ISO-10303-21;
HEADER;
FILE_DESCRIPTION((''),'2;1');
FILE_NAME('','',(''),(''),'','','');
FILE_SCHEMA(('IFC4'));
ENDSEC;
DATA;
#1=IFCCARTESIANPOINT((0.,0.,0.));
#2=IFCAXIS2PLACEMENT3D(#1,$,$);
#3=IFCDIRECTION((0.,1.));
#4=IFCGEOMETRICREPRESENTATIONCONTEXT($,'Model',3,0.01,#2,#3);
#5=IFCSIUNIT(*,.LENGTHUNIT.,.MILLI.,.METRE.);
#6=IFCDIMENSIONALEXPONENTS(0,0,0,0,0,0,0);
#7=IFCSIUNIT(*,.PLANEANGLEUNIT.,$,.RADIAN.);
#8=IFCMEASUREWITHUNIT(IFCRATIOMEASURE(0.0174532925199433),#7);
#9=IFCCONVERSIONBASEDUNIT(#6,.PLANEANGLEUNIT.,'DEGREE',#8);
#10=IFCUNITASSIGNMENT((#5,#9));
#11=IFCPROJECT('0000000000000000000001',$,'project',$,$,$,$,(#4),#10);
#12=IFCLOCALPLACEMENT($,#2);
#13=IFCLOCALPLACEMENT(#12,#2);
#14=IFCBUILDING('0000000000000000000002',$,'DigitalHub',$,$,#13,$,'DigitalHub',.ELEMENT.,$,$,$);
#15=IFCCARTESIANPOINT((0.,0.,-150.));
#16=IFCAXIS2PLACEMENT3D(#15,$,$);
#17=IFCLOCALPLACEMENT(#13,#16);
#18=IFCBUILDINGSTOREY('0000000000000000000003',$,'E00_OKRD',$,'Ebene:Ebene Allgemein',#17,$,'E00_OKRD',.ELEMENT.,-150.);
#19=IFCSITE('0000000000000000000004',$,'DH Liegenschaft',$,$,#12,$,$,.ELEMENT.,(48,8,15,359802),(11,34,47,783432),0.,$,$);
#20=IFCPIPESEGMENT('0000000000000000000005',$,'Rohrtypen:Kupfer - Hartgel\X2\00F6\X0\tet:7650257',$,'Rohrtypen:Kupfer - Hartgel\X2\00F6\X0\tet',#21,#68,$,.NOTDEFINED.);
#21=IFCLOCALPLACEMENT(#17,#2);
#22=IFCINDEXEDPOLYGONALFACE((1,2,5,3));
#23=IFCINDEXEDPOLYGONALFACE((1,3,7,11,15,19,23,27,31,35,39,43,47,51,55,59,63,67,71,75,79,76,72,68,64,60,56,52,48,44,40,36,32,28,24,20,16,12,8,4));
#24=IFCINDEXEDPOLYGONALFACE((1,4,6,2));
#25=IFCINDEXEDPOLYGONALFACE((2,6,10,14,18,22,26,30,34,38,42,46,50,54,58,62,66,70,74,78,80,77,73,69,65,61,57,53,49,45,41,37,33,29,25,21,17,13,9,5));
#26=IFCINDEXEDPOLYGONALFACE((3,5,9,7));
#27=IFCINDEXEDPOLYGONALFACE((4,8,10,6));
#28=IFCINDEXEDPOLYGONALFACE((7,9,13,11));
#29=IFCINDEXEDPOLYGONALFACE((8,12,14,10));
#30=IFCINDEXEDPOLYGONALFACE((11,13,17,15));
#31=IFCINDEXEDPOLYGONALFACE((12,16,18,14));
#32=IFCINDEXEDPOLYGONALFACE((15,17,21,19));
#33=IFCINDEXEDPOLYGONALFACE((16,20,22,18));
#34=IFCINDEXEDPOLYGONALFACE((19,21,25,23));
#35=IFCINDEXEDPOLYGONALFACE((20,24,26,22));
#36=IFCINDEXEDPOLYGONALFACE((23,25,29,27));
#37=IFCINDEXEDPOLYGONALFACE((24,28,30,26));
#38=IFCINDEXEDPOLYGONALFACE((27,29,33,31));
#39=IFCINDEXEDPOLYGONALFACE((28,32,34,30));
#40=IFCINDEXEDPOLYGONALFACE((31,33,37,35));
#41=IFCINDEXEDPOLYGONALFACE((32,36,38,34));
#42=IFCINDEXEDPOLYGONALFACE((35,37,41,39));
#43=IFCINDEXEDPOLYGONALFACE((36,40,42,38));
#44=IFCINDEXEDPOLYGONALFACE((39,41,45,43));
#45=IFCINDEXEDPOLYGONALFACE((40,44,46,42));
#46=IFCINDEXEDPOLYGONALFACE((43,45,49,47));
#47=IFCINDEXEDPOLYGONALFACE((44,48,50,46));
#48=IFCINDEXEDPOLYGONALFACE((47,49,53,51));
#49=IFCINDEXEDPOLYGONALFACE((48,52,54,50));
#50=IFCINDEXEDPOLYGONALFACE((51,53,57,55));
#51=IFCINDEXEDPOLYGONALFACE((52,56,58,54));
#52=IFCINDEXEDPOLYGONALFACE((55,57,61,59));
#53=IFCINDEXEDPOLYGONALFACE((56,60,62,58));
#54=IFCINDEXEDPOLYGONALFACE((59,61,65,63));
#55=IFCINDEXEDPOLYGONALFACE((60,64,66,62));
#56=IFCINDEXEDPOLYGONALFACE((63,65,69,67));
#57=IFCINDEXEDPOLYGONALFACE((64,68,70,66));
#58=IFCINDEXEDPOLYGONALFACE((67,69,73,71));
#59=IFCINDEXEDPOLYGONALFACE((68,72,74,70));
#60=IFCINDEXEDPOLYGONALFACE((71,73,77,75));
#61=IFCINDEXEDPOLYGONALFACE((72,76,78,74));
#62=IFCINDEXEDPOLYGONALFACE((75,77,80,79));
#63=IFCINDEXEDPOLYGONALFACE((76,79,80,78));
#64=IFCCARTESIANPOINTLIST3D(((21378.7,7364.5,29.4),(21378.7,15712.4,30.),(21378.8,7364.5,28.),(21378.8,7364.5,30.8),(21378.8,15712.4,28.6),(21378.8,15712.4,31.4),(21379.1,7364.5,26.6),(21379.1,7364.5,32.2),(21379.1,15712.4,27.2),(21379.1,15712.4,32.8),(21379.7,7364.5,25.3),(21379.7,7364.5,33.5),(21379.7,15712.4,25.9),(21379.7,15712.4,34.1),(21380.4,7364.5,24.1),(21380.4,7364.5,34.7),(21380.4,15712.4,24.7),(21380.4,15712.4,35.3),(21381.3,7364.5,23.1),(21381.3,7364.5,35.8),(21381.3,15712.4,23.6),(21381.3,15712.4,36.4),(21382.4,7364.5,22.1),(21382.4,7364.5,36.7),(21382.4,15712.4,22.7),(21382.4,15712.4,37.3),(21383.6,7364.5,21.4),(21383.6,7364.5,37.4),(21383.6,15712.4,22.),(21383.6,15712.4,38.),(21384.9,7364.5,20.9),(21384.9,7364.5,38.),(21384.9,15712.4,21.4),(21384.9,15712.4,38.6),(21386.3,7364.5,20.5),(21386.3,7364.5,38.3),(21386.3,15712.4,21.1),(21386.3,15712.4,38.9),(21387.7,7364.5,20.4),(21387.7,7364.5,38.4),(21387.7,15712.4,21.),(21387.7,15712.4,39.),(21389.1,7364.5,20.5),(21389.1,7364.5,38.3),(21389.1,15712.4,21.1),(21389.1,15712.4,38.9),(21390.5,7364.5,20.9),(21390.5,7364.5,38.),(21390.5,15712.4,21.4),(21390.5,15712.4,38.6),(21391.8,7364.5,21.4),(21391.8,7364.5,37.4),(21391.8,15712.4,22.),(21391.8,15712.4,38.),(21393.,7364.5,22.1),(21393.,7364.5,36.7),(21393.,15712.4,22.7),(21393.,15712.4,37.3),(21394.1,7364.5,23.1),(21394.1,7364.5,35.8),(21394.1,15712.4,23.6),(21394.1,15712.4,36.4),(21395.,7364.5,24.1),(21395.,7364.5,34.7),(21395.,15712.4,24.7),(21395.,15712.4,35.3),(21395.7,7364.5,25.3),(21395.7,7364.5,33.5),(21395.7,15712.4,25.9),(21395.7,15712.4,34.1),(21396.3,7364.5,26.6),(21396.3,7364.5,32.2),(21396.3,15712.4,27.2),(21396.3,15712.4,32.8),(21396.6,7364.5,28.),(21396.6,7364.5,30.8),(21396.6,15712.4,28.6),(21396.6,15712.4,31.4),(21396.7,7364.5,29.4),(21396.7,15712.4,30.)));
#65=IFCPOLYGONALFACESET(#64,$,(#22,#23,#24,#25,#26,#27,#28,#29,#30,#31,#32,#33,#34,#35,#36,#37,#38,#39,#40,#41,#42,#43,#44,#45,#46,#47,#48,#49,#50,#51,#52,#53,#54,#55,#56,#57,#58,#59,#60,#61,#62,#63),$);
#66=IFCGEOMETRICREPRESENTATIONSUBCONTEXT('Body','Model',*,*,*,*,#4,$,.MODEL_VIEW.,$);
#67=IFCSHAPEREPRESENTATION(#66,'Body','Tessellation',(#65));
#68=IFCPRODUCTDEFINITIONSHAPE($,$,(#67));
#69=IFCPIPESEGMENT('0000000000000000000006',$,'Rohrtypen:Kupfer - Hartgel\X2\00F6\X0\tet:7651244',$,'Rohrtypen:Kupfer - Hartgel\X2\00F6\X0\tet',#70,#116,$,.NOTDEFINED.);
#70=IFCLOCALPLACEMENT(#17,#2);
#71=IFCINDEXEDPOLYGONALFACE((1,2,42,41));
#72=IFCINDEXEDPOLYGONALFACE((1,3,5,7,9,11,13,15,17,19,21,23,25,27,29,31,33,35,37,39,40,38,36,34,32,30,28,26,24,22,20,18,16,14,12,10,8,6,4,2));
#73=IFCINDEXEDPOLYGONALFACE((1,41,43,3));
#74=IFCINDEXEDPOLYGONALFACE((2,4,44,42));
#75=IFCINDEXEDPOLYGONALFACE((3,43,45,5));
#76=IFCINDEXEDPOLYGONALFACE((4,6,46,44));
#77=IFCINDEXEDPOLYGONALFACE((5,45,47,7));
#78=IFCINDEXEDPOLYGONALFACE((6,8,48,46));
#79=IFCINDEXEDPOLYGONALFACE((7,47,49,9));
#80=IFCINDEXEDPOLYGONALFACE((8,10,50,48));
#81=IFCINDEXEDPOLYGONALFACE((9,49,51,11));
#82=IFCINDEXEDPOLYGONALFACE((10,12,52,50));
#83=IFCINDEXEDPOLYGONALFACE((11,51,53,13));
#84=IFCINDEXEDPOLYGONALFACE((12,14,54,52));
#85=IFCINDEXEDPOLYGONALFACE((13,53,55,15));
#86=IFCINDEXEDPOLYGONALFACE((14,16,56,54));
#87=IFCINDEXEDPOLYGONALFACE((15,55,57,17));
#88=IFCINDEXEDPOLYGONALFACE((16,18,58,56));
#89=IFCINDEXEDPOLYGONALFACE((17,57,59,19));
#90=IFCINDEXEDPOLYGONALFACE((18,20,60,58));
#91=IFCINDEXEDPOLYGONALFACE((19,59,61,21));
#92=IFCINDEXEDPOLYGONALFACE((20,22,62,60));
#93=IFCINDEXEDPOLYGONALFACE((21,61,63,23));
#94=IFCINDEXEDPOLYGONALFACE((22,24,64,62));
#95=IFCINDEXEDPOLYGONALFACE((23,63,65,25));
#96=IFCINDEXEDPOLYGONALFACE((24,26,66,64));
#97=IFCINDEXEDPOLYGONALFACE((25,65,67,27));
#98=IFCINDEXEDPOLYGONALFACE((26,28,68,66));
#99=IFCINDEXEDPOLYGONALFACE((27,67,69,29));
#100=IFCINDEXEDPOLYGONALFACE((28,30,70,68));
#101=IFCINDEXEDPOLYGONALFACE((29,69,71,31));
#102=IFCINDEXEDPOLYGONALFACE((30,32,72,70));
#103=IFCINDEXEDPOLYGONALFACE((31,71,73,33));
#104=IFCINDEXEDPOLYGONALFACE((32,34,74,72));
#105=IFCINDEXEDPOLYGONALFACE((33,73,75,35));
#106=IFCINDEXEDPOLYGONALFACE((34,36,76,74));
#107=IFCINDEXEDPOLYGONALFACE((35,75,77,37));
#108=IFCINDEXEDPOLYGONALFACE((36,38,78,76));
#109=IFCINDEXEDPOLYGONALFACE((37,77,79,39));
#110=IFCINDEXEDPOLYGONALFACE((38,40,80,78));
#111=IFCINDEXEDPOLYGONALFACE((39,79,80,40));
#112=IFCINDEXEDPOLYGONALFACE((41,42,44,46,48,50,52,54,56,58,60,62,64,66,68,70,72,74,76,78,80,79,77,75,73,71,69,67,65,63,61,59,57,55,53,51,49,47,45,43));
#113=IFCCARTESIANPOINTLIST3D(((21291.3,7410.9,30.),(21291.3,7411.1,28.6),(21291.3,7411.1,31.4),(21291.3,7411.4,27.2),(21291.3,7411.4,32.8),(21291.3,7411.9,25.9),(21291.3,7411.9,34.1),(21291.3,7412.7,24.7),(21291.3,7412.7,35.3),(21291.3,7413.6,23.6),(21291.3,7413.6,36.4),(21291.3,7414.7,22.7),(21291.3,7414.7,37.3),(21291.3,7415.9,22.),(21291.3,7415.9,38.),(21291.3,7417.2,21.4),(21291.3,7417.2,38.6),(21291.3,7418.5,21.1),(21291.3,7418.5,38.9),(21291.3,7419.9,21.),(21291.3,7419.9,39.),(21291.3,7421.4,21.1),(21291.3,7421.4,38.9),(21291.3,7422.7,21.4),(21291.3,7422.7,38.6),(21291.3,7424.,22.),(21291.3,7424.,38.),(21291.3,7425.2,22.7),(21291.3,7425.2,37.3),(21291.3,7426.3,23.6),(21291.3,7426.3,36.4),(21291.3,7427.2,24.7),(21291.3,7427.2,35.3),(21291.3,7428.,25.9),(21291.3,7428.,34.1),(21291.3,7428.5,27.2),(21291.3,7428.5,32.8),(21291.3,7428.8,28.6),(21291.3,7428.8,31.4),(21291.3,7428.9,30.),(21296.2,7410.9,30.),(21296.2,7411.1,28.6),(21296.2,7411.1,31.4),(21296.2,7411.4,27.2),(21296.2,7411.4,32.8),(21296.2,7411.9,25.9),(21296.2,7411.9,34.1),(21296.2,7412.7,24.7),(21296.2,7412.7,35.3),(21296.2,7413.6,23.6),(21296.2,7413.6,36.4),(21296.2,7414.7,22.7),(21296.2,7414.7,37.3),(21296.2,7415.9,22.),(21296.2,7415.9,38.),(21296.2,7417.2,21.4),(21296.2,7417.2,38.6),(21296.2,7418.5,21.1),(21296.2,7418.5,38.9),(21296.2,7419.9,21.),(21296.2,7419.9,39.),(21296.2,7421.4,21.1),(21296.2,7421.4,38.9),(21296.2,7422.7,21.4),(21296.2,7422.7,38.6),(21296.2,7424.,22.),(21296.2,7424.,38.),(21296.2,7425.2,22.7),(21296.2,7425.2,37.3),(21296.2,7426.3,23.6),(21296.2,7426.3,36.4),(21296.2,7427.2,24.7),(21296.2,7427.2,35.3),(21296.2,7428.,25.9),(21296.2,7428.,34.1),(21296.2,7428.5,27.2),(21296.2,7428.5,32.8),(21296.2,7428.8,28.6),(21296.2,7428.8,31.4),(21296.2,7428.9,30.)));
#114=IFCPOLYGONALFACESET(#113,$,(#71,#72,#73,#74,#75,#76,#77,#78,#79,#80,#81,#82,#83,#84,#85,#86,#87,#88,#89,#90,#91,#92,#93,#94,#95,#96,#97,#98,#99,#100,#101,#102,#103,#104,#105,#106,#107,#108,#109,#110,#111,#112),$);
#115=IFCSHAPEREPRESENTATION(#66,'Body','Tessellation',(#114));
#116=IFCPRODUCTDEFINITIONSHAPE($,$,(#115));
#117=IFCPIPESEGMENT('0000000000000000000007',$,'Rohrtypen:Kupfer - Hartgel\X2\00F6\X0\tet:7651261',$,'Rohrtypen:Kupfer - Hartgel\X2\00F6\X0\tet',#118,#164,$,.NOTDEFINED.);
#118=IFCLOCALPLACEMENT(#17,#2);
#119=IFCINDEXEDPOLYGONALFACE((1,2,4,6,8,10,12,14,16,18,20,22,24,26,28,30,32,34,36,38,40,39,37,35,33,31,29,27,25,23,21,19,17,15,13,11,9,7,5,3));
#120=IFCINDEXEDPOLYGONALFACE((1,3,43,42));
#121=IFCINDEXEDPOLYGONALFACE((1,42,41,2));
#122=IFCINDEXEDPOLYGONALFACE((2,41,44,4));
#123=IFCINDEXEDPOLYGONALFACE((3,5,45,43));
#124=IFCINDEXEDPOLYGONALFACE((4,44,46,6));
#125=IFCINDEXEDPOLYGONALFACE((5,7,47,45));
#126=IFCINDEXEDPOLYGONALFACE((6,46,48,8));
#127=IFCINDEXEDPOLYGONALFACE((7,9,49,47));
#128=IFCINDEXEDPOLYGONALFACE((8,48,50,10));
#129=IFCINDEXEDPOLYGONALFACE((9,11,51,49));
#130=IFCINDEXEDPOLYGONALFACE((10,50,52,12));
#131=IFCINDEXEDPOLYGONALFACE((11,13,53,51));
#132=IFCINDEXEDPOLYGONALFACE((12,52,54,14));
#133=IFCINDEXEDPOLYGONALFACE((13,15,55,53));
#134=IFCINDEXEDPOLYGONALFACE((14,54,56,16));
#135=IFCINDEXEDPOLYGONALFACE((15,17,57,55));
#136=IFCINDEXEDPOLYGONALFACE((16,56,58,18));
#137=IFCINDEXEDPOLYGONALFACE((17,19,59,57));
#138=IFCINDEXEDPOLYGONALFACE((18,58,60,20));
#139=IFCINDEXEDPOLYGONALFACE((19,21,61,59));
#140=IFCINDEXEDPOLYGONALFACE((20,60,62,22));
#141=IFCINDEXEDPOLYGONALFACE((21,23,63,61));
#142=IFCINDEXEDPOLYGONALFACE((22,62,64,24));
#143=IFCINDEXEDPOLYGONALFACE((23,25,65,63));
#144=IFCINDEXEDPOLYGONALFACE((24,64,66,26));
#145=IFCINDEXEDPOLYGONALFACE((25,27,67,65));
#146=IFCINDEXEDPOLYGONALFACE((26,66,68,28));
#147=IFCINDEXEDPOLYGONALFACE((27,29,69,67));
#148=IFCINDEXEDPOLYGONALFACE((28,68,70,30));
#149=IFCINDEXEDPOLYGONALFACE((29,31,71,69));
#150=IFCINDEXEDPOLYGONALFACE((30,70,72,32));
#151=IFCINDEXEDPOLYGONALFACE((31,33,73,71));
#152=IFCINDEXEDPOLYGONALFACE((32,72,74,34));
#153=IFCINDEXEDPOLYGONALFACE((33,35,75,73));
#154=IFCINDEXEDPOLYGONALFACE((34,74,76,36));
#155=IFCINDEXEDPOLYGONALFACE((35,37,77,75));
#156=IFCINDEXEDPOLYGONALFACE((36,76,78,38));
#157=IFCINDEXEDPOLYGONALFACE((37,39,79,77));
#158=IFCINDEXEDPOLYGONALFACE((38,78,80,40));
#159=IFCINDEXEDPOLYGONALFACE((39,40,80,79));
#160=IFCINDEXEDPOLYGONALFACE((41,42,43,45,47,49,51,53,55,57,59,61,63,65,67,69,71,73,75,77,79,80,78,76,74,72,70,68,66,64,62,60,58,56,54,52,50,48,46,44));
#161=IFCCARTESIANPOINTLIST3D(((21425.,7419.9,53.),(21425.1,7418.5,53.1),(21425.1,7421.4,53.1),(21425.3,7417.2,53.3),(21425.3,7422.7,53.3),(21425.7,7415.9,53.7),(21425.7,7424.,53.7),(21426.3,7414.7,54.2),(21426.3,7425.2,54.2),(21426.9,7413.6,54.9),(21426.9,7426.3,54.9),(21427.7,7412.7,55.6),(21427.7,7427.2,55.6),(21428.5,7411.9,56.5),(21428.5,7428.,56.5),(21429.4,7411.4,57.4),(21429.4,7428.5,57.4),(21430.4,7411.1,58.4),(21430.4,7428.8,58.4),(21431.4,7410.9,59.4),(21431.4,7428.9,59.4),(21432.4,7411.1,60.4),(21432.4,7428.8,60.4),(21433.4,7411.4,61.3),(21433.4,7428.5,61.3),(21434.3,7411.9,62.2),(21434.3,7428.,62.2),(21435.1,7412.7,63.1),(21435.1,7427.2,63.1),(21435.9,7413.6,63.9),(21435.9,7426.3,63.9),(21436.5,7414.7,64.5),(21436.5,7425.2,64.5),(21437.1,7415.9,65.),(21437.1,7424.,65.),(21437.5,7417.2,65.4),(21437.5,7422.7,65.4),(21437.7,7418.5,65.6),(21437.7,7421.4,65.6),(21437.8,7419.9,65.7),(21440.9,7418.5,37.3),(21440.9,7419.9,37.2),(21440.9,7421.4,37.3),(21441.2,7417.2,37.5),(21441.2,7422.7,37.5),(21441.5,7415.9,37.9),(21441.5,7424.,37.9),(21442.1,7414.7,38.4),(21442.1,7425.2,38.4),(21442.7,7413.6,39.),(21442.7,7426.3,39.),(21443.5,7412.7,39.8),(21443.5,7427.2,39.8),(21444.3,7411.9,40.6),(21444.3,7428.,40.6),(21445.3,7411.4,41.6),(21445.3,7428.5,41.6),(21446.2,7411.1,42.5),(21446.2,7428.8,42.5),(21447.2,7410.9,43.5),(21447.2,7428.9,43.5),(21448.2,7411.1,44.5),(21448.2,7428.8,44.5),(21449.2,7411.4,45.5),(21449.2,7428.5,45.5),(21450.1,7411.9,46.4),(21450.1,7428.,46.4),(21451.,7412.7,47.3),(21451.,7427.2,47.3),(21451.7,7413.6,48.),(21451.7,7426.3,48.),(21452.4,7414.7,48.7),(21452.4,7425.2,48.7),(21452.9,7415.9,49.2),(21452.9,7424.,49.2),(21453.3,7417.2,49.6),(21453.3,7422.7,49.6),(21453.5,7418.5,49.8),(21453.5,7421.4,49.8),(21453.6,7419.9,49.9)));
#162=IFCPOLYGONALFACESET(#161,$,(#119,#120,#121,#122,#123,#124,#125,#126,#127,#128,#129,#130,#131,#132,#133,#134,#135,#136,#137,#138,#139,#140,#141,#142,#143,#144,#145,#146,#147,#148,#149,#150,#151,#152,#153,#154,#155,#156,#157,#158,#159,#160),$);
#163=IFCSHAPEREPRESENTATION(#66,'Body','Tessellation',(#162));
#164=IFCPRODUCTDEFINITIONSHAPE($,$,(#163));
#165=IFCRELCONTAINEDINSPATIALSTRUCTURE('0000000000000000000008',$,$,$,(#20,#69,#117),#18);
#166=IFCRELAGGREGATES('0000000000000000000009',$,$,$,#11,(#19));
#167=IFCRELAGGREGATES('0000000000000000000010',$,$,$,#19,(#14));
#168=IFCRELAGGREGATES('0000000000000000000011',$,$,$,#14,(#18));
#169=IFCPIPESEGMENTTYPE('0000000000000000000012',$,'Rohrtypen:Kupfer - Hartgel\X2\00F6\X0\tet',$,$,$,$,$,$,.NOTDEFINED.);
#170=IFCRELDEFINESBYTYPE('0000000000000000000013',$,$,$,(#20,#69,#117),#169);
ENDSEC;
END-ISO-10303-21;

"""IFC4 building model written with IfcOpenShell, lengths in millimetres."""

from ifc_helpers import new_model, entity, si_unit, converted_unit, direction, frame, origin, place, context, subcontext, project, spatial, indexed_curve, outline, extrude, type_object, element, save


model = new_model("IFC4")

# Units and contexts
model_context = context("Model", 3, precision=0.01, world=origin(), true_north=direction((0.0, 1.0)))
body_context = subcontext(model_context, "Body", "Model", "MODEL_VIEW")
ifc_project = project(units=[si_unit("LENGTHUNIT", "METRE", prefix="MILLI"), converted_unit("PLANEANGLEUNIT", "DEGREE", entity("IfcRatioMeasure", 0.0174532925199433), si_unit("PLANEANGLEUNIT", "RADIAN"), dimensions=[0, 0, 0, 0, 0, 0, 0])], contexts=[model_context])

# Site, building, storey
site_placement = place(None, origin())
site = spatial("IfcSite", under=ifc_project, at=site_placement, Name="DH Liegenschaft", CompositionType="ELEMENT", RefLatitude=(48, 8, 15, 359802), RefLongitude=(11, 34, 47, 783432), RefElevation=0.0)
building_placement = place(site_placement, origin())
building = spatial("IfcBuilding", under=site, at=building_placement, Name="DigitalHub", LongName="DigitalHub", CompositionType="ELEMENT")
storey_placement = place(building_placement, frame((0.0, 0.0, -150.0)))
storey = spatial("IfcBuildingStorey", under=building, at=storey_placement, Name="E00_OKRD", ObjectType="Ebene:Ebene Allgemein", LongName="E00_OKRD", CompositionType="ELEMENT", Elevation=-150.0)

# Pipe segments
pipe_segment_type = type_object("IfcPipeSegmentType", Name="Rohrtypen:Kupfer - Hartgelötet", PredefinedType="NOTDEFINED")
pipe_segment_1_placement = place(storey_placement, frame((21377.1, 7364.5, 18.8)))
element("IfcPipeSegment", 1, at=pipe_segment_1_placement, inside=storey, type_object=pipe_segment_type, Name="Rohrtypen:Kupfer - Hartgelötet:7650257", ObjectType="Rohrtypen:Kupfer - Hartgelötet", PredefinedType="NOTDEFINED", context=body_context, shape_type="SweptSolid", body=[
    extrude(outline(indexed_curve([(9.0, 0.0), (8.9, 1.4), (8.6, 2.8), (8.0, 4.1), (7.3, 5.3), (6.4, 6.4), (5.3, 7.3), (4.1, 8.0), (2.8, 8.6), (1.4, 8.9), (0.0, 9.0), (-1.4, 8.9), (-2.8, 8.6), (-4.1, 8.0), (-5.3, 7.3), (-6.4, 6.4), (-7.3, 5.3), (-8.0, 4.1), (-8.6, 2.8), (-8.9, 1.4), (-9.0, 0.0), (-8.9, -1.4), (-8.6, -2.8), (-8.0, -4.1), (-7.3, -5.3), (-6.4, -6.4), (-5.3, -7.3), (-4.1, -8.0), (-2.8, -8.6), (-1.4, -8.9), (0.0, -9.0), (1.4, -8.9), (2.8, -8.6), (4.1, -8.0), (5.3, -7.3), (6.4, -6.4), (7.3, -5.3), (8.0, -4.1), (8.6, -2.8), (8.9, -1.4), (9.0, 0.0)], self_intersect=False)), frame((10.6, 0.0, 10.6), z_axis=(0.0, 1.0, 0.000069), x_axis=(1.0, 0.0, 0.0)), (0.0, 0.0, 1.0), 8347.9),
])
pipe_segment_2_placement = place(storey_placement, frame((21291.3, 7409.3, 19.4)))
element("IfcPipeSegment", 2, at=pipe_segment_2_placement, inside=storey, type_object=pipe_segment_type, Name="Rohrtypen:Kupfer - Hartgelötet:7651244", ObjectType="Rohrtypen:Kupfer - Hartgelötet", PredefinedType="NOTDEFINED", context=body_context, shape_type="SweptSolid", body=[
    extrude(outline(indexed_curve([(9.0, 0.0), (8.9, 1.4), (8.6, 2.8), (8.0, 4.1), (7.3, 5.3), (6.4, 6.4), (5.3, 7.3), (4.1, 8.0), (2.8, 8.6), (1.4, 8.9), (0.0, 9.0), (-1.4, 8.9), (-2.8, 8.6), (-4.1, 8.0), (-5.3, 7.3), (-6.4, 6.4), (-7.3, 5.3), (-8.0, 4.1), (-8.6, 2.8), (-8.9, 1.4), (-9.0, 0.0), (-8.9, -1.4), (-8.6, -2.8), (-8.0, -4.1), (-7.3, -5.3), (-6.4, -6.4), (-5.3, -7.3), (-4.1, -8.0), (-2.8, -8.6), (-1.4, -8.9), (0.0, -9.0), (1.4, -8.9), (2.8, -8.6), (4.1, -8.0), (5.3, -7.3), (6.4, -6.4), (7.3, -5.3), (8.0, -4.1), (8.6, -2.8), (8.9, -1.4), (9.0, 0.0)], self_intersect=False)), frame((0.0, 10.6, 10.6), z_axis=(1.0, 0.0, 0.0), x_axis=(0.0, -1.0, 0.0)), (0.0, 0.0, 1.0), 4.9),
])
pipe_segment_3_placement = place(storey_placement, frame((21423.4, 7409.3, 35.6)))
element("IfcPipeSegment", 3, at=pipe_segment_3_placement, inside=storey, type_object=pipe_segment_type, Name="Rohrtypen:Kupfer - Hartgelötet:7651261", ObjectType="Rohrtypen:Kupfer - Hartgelötet", PredefinedType="NOTDEFINED", context=body_context, shape_type="SweptSolid", body=[
    extrude(outline(indexed_curve([(9.0, 0.0), (8.9, 1.4), (8.6, 2.8), (8.0, 4.1), (7.3, 5.3), (6.4, 6.4), (5.3, 7.3), (4.1, 8.0), (2.8, 8.6), (1.4, 8.9), (0.0, 9.0), (-1.4, 8.9), (-2.8, 8.6), (-4.1, 8.0), (-5.3, 7.3), (-6.4, 6.4), (-7.3, 5.3), (-8.0, 4.1), (-8.6, 2.8), (-8.9, 1.4), (-9.0, 0.0), (-8.9, -1.4), (-8.6, -2.8), (-8.0, -4.1), (-7.3, -5.3), (-6.4, -6.4), (-5.3, -7.3), (-4.1, -8.0), (-2.8, -8.6), (-1.4, -8.9), (0.0, -9.0), (1.4, -8.9), (2.8, -8.6), (4.1, -8.0), (5.3, -7.3), (6.4, -6.4), (7.3, -5.3), (8.0, -4.1), (8.6, -2.8), (8.9, -1.4), (9.0, 0.0)], self_intersect=False)), frame((23.8, 10.6, 8.0), z_axis=(-0.707107, 0.0, 0.707107), x_axis=(0.0, -1.0, 0.0)), (0.0, 0.0, 1.0), 22.4),
])

save(model, "model.ifc")
